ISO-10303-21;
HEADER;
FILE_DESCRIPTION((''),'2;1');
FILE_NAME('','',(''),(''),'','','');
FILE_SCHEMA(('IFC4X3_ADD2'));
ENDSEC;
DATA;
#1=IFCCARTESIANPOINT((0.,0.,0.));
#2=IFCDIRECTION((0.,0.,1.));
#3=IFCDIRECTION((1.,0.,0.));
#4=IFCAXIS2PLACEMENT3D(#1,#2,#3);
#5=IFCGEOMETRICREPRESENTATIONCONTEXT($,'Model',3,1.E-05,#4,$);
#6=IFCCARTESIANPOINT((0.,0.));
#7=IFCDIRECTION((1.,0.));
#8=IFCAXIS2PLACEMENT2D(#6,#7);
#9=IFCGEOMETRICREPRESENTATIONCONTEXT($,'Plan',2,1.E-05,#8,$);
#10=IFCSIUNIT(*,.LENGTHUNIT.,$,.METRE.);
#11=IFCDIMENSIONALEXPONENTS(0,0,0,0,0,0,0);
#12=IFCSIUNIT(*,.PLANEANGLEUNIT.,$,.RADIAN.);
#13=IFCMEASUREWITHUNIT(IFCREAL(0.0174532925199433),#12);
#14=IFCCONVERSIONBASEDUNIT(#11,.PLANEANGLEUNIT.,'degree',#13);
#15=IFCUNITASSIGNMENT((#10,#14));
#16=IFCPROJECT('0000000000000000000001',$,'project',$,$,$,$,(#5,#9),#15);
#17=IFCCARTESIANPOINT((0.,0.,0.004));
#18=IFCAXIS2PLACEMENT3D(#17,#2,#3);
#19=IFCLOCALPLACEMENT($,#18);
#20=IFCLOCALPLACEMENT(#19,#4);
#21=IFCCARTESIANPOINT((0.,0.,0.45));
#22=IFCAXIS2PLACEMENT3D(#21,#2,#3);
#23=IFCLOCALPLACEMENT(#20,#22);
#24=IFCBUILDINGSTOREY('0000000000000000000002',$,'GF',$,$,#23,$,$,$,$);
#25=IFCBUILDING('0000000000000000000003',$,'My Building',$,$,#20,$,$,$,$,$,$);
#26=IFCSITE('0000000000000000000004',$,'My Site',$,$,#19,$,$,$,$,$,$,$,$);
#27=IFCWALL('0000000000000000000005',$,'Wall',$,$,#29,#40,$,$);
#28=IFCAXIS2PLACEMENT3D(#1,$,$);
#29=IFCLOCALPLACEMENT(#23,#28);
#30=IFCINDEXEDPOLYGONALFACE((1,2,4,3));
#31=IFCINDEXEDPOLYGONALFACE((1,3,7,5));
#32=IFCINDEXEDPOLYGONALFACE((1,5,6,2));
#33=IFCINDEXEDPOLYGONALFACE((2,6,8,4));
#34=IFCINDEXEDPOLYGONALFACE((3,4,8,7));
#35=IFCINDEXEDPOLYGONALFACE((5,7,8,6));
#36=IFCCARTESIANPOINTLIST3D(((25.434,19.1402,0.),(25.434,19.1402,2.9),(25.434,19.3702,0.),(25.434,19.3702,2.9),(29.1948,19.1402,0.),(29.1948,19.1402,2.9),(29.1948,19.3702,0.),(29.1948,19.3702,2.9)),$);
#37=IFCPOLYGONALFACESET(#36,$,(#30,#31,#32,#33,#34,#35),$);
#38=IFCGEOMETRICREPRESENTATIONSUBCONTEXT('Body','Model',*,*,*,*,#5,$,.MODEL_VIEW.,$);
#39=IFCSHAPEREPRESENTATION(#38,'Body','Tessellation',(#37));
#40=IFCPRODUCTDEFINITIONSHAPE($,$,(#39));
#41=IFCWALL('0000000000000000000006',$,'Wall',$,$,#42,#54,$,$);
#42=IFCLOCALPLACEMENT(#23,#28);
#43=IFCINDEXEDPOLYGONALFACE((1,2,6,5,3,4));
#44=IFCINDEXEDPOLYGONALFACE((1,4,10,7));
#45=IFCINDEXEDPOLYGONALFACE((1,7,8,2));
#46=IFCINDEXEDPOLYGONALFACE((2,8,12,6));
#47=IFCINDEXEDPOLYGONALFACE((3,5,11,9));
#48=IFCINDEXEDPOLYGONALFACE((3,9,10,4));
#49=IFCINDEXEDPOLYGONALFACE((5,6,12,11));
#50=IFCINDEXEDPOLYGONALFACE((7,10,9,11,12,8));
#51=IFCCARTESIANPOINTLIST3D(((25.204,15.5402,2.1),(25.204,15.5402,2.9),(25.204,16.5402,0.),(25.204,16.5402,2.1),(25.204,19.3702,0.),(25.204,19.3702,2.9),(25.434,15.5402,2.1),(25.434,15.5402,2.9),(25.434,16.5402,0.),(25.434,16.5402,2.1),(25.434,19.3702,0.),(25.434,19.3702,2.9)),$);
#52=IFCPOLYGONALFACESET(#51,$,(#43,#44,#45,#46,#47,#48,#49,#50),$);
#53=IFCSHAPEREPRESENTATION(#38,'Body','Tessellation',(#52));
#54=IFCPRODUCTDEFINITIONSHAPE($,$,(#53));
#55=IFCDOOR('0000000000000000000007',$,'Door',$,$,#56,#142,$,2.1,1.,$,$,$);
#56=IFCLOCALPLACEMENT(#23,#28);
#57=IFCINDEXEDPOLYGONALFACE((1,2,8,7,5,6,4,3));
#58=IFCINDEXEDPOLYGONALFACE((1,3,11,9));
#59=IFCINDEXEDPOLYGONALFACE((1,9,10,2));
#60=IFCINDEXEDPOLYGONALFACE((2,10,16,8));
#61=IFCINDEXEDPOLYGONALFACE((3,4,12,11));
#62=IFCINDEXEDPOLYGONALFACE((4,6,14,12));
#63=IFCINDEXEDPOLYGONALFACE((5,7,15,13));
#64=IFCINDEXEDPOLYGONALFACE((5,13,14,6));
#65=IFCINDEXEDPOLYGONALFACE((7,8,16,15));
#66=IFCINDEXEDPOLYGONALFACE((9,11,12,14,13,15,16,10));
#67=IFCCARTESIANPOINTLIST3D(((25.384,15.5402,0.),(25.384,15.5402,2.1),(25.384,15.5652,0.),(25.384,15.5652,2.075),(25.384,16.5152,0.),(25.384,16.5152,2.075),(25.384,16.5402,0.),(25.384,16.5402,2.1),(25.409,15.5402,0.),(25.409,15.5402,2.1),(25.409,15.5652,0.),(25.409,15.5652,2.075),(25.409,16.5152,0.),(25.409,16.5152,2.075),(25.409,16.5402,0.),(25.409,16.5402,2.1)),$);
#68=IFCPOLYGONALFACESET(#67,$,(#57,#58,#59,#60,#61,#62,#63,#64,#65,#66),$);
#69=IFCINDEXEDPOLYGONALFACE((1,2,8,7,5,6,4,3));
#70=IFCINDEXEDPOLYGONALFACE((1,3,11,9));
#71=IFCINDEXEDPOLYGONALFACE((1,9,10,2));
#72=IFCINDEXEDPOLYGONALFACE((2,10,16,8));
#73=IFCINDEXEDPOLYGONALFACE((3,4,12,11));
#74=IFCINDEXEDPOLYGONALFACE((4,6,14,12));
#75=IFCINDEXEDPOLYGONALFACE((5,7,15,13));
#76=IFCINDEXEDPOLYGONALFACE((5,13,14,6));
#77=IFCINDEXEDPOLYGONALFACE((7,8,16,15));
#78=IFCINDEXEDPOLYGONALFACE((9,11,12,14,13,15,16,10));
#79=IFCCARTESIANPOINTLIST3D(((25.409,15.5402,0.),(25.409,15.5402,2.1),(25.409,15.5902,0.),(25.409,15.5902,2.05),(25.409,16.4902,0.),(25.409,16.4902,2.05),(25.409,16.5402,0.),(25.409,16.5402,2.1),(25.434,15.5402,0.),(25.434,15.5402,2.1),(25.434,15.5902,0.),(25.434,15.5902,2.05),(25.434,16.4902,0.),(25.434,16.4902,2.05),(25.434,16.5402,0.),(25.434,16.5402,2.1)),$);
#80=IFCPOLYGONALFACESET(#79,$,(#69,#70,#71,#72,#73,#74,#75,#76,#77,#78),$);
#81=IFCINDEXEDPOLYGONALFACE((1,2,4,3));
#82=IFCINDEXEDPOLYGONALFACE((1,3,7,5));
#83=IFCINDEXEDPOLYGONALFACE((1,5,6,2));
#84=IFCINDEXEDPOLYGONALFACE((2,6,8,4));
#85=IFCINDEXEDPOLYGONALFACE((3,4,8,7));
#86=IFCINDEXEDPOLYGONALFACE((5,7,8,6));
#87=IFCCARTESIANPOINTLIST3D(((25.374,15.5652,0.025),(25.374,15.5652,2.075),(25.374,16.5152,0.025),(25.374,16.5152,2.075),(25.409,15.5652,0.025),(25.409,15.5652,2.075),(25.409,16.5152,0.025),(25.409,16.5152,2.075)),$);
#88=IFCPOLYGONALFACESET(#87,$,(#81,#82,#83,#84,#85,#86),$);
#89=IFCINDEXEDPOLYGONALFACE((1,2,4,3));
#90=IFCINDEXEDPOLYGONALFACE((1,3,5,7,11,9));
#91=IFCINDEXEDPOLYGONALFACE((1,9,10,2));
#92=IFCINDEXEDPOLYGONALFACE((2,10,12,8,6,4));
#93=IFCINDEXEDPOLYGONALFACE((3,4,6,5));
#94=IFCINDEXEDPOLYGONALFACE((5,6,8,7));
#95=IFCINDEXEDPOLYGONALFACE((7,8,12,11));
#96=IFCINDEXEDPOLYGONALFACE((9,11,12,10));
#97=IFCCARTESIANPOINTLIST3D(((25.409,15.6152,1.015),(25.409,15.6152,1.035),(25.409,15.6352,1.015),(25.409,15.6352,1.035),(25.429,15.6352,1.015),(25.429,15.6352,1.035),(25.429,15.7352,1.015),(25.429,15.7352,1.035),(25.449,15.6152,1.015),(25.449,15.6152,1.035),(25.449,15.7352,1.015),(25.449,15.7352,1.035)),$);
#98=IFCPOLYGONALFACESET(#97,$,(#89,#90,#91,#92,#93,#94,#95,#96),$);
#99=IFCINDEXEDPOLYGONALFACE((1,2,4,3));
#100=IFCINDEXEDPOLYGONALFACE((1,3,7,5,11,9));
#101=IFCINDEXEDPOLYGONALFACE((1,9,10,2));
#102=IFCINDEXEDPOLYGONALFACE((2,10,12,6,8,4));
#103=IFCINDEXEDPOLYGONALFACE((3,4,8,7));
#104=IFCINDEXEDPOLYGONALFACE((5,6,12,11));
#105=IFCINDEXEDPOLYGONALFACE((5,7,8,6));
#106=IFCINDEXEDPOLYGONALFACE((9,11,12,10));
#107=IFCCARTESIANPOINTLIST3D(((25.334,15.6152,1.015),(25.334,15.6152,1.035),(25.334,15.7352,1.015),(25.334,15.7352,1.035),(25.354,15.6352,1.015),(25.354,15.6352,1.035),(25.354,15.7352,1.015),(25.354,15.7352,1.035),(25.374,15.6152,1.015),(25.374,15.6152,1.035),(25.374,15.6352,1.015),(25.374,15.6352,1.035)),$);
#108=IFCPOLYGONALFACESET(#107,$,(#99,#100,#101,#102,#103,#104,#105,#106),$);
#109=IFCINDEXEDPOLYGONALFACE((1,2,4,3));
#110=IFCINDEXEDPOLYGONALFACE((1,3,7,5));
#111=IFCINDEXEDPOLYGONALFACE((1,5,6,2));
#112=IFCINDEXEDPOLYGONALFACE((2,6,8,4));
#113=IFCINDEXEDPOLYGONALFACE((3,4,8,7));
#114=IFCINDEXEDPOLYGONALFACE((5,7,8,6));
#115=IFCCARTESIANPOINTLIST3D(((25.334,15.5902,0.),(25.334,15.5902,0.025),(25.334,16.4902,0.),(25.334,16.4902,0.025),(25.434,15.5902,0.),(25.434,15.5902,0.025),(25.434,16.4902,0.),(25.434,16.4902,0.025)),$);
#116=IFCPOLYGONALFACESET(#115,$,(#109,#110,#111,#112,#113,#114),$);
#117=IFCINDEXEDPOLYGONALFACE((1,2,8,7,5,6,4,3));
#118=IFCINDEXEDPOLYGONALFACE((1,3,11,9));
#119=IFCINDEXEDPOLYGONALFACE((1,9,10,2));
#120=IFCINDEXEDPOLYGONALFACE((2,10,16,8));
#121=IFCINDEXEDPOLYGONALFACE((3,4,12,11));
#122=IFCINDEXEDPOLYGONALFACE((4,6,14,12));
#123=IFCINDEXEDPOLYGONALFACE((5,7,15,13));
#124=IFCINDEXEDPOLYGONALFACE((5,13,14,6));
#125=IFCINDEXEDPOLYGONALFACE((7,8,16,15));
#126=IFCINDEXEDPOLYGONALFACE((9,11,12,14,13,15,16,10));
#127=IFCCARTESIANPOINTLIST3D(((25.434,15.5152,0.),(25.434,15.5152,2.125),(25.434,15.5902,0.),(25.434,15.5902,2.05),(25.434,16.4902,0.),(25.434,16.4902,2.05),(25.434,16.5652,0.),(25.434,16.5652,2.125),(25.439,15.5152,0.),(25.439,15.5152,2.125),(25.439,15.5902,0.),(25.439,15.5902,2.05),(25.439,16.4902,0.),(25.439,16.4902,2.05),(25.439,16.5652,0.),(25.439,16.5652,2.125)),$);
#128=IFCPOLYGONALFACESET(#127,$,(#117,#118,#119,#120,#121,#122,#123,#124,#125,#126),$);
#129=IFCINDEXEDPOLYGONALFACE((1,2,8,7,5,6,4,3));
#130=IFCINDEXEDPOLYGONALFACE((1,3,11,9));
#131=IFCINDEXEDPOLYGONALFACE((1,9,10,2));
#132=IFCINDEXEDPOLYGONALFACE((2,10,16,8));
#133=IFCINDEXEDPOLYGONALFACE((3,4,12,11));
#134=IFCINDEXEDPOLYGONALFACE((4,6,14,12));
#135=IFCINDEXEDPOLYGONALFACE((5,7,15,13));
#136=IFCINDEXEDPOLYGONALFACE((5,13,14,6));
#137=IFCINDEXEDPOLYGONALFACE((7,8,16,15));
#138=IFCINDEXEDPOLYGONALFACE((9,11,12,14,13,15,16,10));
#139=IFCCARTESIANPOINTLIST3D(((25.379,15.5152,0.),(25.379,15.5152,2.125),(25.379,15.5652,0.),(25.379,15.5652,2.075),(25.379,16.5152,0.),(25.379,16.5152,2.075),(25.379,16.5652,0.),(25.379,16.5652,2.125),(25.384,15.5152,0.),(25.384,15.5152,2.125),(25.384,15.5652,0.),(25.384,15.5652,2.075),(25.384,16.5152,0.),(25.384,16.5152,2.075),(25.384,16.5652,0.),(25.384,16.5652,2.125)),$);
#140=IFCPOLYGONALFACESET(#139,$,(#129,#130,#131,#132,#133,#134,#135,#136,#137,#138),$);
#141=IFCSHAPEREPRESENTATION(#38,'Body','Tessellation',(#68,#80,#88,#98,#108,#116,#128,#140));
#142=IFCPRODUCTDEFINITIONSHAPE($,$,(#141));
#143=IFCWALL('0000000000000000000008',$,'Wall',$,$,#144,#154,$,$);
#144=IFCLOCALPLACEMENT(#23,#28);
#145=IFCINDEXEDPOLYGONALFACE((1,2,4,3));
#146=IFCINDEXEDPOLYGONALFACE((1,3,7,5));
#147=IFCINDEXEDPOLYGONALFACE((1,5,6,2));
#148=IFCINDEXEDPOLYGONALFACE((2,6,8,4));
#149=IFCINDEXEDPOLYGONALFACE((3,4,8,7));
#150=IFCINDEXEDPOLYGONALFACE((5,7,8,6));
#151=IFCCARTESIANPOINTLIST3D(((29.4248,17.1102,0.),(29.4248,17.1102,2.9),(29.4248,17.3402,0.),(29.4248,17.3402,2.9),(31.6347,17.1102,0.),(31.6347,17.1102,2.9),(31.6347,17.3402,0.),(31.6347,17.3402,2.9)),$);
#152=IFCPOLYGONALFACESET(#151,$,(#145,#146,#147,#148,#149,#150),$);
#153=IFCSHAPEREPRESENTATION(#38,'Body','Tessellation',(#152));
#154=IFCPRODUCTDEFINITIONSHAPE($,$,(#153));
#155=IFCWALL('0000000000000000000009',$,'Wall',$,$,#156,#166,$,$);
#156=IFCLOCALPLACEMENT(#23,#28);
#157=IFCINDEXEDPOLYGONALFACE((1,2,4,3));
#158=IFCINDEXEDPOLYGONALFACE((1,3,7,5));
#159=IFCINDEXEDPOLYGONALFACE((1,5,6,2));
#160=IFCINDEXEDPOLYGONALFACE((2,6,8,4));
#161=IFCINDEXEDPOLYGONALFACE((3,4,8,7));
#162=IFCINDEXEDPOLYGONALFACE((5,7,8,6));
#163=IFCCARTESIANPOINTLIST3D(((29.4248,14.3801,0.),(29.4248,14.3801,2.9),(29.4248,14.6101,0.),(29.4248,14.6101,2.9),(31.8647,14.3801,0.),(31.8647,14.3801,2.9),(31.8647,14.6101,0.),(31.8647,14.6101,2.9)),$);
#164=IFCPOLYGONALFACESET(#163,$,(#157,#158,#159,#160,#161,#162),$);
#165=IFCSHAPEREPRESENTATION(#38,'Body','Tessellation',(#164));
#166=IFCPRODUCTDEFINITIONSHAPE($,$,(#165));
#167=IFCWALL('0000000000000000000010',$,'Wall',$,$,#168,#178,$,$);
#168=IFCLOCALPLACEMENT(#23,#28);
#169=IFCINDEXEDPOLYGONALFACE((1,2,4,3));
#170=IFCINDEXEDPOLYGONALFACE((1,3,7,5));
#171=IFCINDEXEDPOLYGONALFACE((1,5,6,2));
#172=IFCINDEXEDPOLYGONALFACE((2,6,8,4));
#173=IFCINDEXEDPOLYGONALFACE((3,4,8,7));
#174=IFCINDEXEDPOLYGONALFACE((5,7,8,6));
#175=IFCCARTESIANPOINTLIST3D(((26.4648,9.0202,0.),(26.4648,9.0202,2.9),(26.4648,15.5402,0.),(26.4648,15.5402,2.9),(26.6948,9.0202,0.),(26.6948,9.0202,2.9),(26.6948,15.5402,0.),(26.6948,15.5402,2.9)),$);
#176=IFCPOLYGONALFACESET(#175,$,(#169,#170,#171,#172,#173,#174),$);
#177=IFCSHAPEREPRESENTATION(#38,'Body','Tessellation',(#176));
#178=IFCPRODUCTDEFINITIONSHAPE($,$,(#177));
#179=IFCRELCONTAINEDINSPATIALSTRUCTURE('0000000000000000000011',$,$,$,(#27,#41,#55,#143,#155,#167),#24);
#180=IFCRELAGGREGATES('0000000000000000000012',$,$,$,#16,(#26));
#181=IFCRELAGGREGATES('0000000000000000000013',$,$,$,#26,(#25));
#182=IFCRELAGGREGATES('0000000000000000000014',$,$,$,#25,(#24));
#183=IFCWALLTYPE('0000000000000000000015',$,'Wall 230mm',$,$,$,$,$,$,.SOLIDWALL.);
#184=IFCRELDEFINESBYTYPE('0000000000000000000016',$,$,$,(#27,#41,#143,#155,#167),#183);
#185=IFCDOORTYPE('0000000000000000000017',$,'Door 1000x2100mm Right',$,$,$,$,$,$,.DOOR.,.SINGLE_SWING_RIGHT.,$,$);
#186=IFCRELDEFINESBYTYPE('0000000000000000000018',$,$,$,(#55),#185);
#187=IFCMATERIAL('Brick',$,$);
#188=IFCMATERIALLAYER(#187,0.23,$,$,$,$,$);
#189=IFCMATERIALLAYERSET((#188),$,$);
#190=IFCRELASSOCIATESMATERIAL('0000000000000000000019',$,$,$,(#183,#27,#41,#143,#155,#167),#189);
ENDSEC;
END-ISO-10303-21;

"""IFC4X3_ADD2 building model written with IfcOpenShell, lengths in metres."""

from ifc_helpers import new_model, entity, si_unit, converted_unit, frame, origin_with_axes, origin_2d_with_axis, place, context, subcontext, project, spatial, line, indexed_curve, outline, extrude, shape, source, transform, mapped, material, layer, layer_set, layer_usage, type_object, type_shapes, element, fill, save


model = new_model("IFC4X3_ADD2")

# Units and contexts
model_context = context("Model", 3, precision=1e-05, world=origin_with_axes())
plan_context = context("Plan", 2, precision=1e-05, world=origin_2d_with_axis())
body_context_1 = subcontext(model_context, "Body", "Model", "MODEL_VIEW")
body_context_2 = subcontext(plan_context, "Body", "Plan", "PLAN_VIEW")
ifc_project = project(units=[si_unit("LENGTHUNIT", "METRE"), converted_unit("PLANEANGLEUNIT", "degree", entity("IfcReal", 0.0174532925199433), si_unit("PLANEANGLEUNIT", "RADIAN"), dimensions=[0, 0, 0, 0, 0, 0, 0])], contexts=[model_context, plan_context])

# Site, building, storey
site_placement = place(None, frame((0.0, 0.0, 0.004), z_axis=(0.0, 0.0, 1.0), x_axis=(1.0, 0.0, 0.0)))
site = spatial("IfcSite", under=ifc_project, at=site_placement, Name="My Site")
building_placement = place(site_placement, origin_with_axes())
building = spatial("IfcBuilding", under=site, at=building_placement, Name="My Building")
storey_placement = place(building_placement, frame((0.0, 0.0, 0.45), z_axis=(0.0, 0.0, 1.0), x_axis=(1.0, 0.0, 0.0)))
storey = spatial("IfcBuildingStorey", under=building, at=storey_placement, Name="GF")

# Shared definitions
ifc_material = material(Name="Brick")

# Shared definitions
ifc_layer_1 = layer(ifc_material, 0.23)
ifc_layer_set_1 = layer_set([ifc_layer_1])
wall_type_1 = type_object("IfcWallType", Name="Wall 230mm", PredefinedType="SOLIDWALL", material=ifc_layer_set_1)

# Wall
ifc_layer_usage_1 = layer_usage(ifc_layer_set_1, "AXIS2", "POSITIVE", 0.0)
wall_1_placement = place(storey_placement, frame((29.1948, 19.3702, 0.0), z_axis=(0.0, 0.0, 1.0), x_axis=(-1.0, 0.0, 0.0)))
element("IfcWall", 1, at=wall_1_placement, inside=storey, type_object=wall_type_1, material=ifc_layer_usage_1, Name="Wall", context=body_context_1, shape_type="SweptSolid", body=[
    extrude(outline(indexed_curve([(0.0, 0.0), (0.0, 0.23), (3.7608, 0.23), (3.7608, 0.0), (0.0, 0.0)], self_intersect=False)), origin_with_axes(), (0.0, 0.0, 1.0), 2.9),
])

# Wall, opening, door
ifc_layer_usage_2 = layer_usage(ifc_layer_set_1, "AXIS2", "POSITIVE", 0.0)
wall_2_placement = place(storey_placement, frame((25.434, 15.5402, 0.0), z_axis=(0.0, 0.0, 1.0), x_axis=(0.000001, 1.0, 0.0)))
wall_2 = element("IfcWall", 2, at=wall_2_placement, inside=storey, type_object=wall_type_1, material=ifc_layer_usage_2, Name="Wall", context=body_context_1, shape_type="SweptSolid", body=[
    extrude(outline(indexed_curve([(0.0, 0.0), (0.0, 0.23), (3.83, 0.23), (3.83, 0.0), (0.0, 0.0)], self_intersect=False)), origin_with_axes(), (0.0, 0.0, 1.0), 2.9),
])
shared_shape_1 = source(origin_with_axes(), body_context_1, "Body", "SweptSolid", [
    extrude(outline(indexed_curve([(0.0, 0.0), (1.0, 0.0), (1.0, 2.1), (0.0, 2.1)], segments=[line(1, 2, 3, 4, 1)])), frame((0.0, -0.6, 0.0), z_axis=(0.0, -1.0, 0.0), x_axis=(1.0, 0.0, 0.0)), (0.0, 0.0, -1.0), 1.2),
])
opening_1_placement = place(wall_2_placement, frame((0.0, 0.0, 0.0), z_axis=(0.0, 0.0, 1.0), x_axis=(1.0, 0.0, 0.0)))
opening_1 = element("IfcOpeningElement", 3, at=opening_1_placement, cuts=wall_2, PredefinedType="OPENING", context=body_context_1, shape_type="MappedRepresentation", body=[
    mapped(shared_shape_1, transform((0.0, 0.0, 0.0), x_axis=(1.0, 0.0, 0.0), y_axis=(0.0, 1.0, 0.0), z_axis=(0.0, 0.0, 1.0), scale=1.0)),
])
door_type = type_object("IfcDoorType", Name="Door 1000x2100mm Right", OperationType="SINGLE_SWING_RIGHT", PredefinedType="DOOR")
shared_shape_2 = source(origin_with_axes(), body_context_1, "Body", "SweptSolid", [
    extrude(outline(indexed_curve([(0.0, 0.0), (0.0, 2.1), (1.0, 2.1), (1.0, 0.0), (0.975, 0.0), (0.975, 2.075), (0.025, 2.075), (0.025, 0.0)], segments=[line(1, 2, 3, 4, 5, 6, 7, 8, 1)])), frame((0.0, 0.025, 0.0), z_axis=(0.0, -1.0, 0.0), x_axis=(1.0, 0.0, 0.0)), (0.0, 0.0, -1.0), 0.025),
    extrude(outline(indexed_curve([(0.0, 0.0), (0.0, 2.1), (1.0, 2.1), (1.0, 0.0), (0.95, 0.0), (0.95, 2.05), (0.05, 2.05), (0.05, 0.0)], segments=[line(1, 2, 3, 4, 5, 6, 7, 8, 1)])), frame((0.0, 0.0, 0.0), z_axis=(0.0, -1.0, 0.0), x_axis=(1.0, 0.0, 0.0)), (0.0, 0.0, -1.0), 0.025),
    extrude(outline(indexed_curve([(0.0, 0.0), (0.95, 0.0), (0.95, 0.035), (0.0, 0.035)], segments=[line(1, 2, 3, 4, 1)])), frame((0.025, 0.025, 0.025), z_axis=(0.0, 0.0, 1.0), x_axis=(1.0, 0.0, 0.0)), (0.0, 0.0, 1.0), 2.05),
    extrude(outline(indexed_curve([(0.0, 0.0), (0.0, -0.04), (0.12, -0.04), (0.12, -0.02), (0.02, -0.02), (0.02, 0.0)], segments=[line(1, 2, 3, 4, 5, 6, 1)])), frame((0.075, 0.025, 1.015), z_axis=(0.0, 0.0, 1.0), x_axis=(1.0, 0.0, 0.0)), (0.0, 0.0, 1.0), 0.02),
    extrude(outline(indexed_curve([(0.0, 0.0), (0.0, 0.04), (0.12, 0.04), (0.12, 0.02), (0.02, 0.02), (0.02, 0.0)], segments=[line(1, 2, 3, 4, 5, 6, 1)])), frame((0.075, 0.06, 1.015), z_axis=(0.0, 0.0, 1.0), x_axis=(1.0, 0.0, 0.0)), (0.0, 0.0, 1.0), 0.02),
    extrude(outline(indexed_curve([(0.0, 0.0), (0.9, 0.0), (0.9, 0.1), (0.0, 0.1)], segments=[line(1, 2, 3, 4, 1)])), frame((0.05, 0.0, 0.0), z_axis=(0.0, 0.0, 1.0), x_axis=(1.0, 0.0, 0.0)), (0.0, 0.0, 1.0), 0.025),
    extrude(outline(indexed_curve([(0.0, 0.0), (0.0, 2.125), (1.05, 2.125), (1.05, 0.0), (0.975, 0.0), (0.975, 2.05), (0.075, 2.05), (0.075, 0.0)], segments=[line(1, 2, 3, 4, 5, 6, 7, 8, 1)])), frame((-0.025, -0.005, 0.0), z_axis=(0.0, -1.0, 0.0), x_axis=(1.0, 0.0, 0.0)), (0.0, 0.0, -1.0), 0.005),
    extrude(outline(indexed_curve([(0.0, 0.0), (0.0, 2.125), (1.05, 2.125), (1.05, 0.0), (1.0, 0.0), (1.0, 2.075), (0.05, 2.075), (0.05, 0.0)], segments=[line(1, 2, 3, 4, 5, 6, 7, 8, 1)])), frame((-0.025, 0.05, 0.0), z_axis=(0.0, -1.0, 0.0), x_axis=(1.0, 0.0, 0.0)), (0.0, 0.0, -1.0), 0.005),
])
shared_shape_3 = source(origin_with_axes(), body_context_2, "Body", "Curve2D", [
    entity("IfcIndexedPolyCurve", entity("IfcCartesianPointList2D", [[0.0, 0.0], [0.0, 0.05], [0.025, 0.05], [0.025, 0.025], [0.05, 0.025], [0.05, 0.0]]), [entity("IfcLineIndex", [1, 2, 3, 4, 5, 6, 1])]),
    entity("IfcIndexedPolyCurve", entity("IfcCartesianPointList2D", [[1.0, 0.0], [1.0, 0.05], [0.975, 0.05], [0.975, 0.025], [0.95, 0.025], [0.95, 0.0]]), [entity("IfcLineIndex", [1, 2, 3, 4, 5, 6, 1])]),
    entity("IfcTrimmedCurve", entity("IfcEllipse", entity("IfcAxis2Placement2D", entity("IfcCartesianPoint", [0.94, 0.05]), entity("IfcDirection", [1.0, 0.0])), 0.915, 0.95), [entity("IfcCartesianPoint", [0.94, 1.0])], [entity("IfcCartesianPoint", [0.025, 0.05])], True, "CARTESIAN"),
    entity("IfcIndexedPolyCurve", entity("IfcCartesianPointList2D", [[0.975, 0.05], [0.94, 0.05], [0.94, 1.0], [0.975, 1.0]]), [entity("IfcLineIndex", [1, 2, 3, 4, 1])]),
])
type_shapes(door_type, [shared_shape_2, shared_shape_3])
door_1_placement = place(opening_1_placement, origin_with_axes())
door_1 = element("IfcDoor", 4, at=door_1_placement, inside=storey, type_object=door_type, Name="Door", OverallHeight=2.1, OverallWidth=1.0, shapes=[
    shape(body_context_1, "Body", "MappedRepresentation", [mapped(shared_shape_2, transform((0.0, 0.0, 0.0), x_axis=(1.0, 0.0, 0.0), y_axis=(0.0, 1.0, 0.0), z_axis=(0.0, 0.0, 1.0), scale=1.0))]),
    shape(body_context_2, "Body", "MappedRepresentation", [mapped(shared_shape_3, transform((0.0, 0.0, 0.0), x_axis=(1.0, 0.0, 0.0), y_axis=(0.0, 1.0, 0.0), z_axis=(0.0, 0.0, 1.0), scale=1.0))]),
])
fill(opening_1, door_1)

# Walls
ifc_layer_usage_3 = layer_usage(ifc_layer_set_1, "AXIS2", "POSITIVE", 0.0)
wall_3_placement = place(storey_placement, frame((31.6347, 17.3402, 0.0), z_axis=(0.0, 0.0, 1.0), x_axis=(-1.0, 0.0, 0.0)))
element("IfcWall", 5, at=wall_3_placement, inside=storey, type_object=wall_type_1, material=ifc_layer_usage_3, Name="Wall", context=body_context_1, shape_type="SweptSolid", body=[
    extrude(outline(indexed_curve([(0.0, 0.0), (0.0, 0.23), (2.21, 0.23), (2.21, 0.0), (0.0, 0.0)], self_intersect=False)), origin_with_axes(), (0.0, 0.0, 1.0), 2.9),
])
ifc_layer_usage_4 = layer_usage(ifc_layer_set_1, "AXIS2", "POSITIVE", 0.0)
wall_4_placement = place(storey_placement, frame((31.8647, 14.6101, 0.0), z_axis=(0.0, 0.0, 1.0), x_axis=(-1.0, 0.0, 0.0)))
element("IfcWall", 6, at=wall_4_placement, inside=storey, type_object=wall_type_1, material=ifc_layer_usage_4, Name="Wall", context=body_context_1, shape_type="SweptSolid", body=[
    extrude(outline(indexed_curve([(0.0, 0.0), (0.0, 0.23), (2.44, 0.23), (2.44, 0.0), (0.0, 0.0)], self_intersect=False)), origin_with_axes(), (0.0, 0.0, 1.0), 2.9),
])
ifc_layer_usage_5 = layer_usage(ifc_layer_set_1, "AXIS2", "POSITIVE", 0.0)
wall_5_placement = place(storey_placement, frame((26.6948, 9.0202, 0.0), z_axis=(0.0, 0.0, 1.0), x_axis=(0.000001, 1.0, 0.0)))
element("IfcWall", 7, at=wall_5_placement, inside=storey, type_object=wall_type_1, material=ifc_layer_usage_5, Name="Wall", context=body_context_1, shape_type="SweptSolid", body=[
    extrude(outline(indexed_curve([(0.0, 0.0), (0.0, 0.23), (6.52, 0.23), (6.52, 0.0), (0.0, 0.0)], self_intersect=False)), origin_with_axes(), (0.0, 0.0, 1.0), 2.9),
])

save(model, "model.ifc")
